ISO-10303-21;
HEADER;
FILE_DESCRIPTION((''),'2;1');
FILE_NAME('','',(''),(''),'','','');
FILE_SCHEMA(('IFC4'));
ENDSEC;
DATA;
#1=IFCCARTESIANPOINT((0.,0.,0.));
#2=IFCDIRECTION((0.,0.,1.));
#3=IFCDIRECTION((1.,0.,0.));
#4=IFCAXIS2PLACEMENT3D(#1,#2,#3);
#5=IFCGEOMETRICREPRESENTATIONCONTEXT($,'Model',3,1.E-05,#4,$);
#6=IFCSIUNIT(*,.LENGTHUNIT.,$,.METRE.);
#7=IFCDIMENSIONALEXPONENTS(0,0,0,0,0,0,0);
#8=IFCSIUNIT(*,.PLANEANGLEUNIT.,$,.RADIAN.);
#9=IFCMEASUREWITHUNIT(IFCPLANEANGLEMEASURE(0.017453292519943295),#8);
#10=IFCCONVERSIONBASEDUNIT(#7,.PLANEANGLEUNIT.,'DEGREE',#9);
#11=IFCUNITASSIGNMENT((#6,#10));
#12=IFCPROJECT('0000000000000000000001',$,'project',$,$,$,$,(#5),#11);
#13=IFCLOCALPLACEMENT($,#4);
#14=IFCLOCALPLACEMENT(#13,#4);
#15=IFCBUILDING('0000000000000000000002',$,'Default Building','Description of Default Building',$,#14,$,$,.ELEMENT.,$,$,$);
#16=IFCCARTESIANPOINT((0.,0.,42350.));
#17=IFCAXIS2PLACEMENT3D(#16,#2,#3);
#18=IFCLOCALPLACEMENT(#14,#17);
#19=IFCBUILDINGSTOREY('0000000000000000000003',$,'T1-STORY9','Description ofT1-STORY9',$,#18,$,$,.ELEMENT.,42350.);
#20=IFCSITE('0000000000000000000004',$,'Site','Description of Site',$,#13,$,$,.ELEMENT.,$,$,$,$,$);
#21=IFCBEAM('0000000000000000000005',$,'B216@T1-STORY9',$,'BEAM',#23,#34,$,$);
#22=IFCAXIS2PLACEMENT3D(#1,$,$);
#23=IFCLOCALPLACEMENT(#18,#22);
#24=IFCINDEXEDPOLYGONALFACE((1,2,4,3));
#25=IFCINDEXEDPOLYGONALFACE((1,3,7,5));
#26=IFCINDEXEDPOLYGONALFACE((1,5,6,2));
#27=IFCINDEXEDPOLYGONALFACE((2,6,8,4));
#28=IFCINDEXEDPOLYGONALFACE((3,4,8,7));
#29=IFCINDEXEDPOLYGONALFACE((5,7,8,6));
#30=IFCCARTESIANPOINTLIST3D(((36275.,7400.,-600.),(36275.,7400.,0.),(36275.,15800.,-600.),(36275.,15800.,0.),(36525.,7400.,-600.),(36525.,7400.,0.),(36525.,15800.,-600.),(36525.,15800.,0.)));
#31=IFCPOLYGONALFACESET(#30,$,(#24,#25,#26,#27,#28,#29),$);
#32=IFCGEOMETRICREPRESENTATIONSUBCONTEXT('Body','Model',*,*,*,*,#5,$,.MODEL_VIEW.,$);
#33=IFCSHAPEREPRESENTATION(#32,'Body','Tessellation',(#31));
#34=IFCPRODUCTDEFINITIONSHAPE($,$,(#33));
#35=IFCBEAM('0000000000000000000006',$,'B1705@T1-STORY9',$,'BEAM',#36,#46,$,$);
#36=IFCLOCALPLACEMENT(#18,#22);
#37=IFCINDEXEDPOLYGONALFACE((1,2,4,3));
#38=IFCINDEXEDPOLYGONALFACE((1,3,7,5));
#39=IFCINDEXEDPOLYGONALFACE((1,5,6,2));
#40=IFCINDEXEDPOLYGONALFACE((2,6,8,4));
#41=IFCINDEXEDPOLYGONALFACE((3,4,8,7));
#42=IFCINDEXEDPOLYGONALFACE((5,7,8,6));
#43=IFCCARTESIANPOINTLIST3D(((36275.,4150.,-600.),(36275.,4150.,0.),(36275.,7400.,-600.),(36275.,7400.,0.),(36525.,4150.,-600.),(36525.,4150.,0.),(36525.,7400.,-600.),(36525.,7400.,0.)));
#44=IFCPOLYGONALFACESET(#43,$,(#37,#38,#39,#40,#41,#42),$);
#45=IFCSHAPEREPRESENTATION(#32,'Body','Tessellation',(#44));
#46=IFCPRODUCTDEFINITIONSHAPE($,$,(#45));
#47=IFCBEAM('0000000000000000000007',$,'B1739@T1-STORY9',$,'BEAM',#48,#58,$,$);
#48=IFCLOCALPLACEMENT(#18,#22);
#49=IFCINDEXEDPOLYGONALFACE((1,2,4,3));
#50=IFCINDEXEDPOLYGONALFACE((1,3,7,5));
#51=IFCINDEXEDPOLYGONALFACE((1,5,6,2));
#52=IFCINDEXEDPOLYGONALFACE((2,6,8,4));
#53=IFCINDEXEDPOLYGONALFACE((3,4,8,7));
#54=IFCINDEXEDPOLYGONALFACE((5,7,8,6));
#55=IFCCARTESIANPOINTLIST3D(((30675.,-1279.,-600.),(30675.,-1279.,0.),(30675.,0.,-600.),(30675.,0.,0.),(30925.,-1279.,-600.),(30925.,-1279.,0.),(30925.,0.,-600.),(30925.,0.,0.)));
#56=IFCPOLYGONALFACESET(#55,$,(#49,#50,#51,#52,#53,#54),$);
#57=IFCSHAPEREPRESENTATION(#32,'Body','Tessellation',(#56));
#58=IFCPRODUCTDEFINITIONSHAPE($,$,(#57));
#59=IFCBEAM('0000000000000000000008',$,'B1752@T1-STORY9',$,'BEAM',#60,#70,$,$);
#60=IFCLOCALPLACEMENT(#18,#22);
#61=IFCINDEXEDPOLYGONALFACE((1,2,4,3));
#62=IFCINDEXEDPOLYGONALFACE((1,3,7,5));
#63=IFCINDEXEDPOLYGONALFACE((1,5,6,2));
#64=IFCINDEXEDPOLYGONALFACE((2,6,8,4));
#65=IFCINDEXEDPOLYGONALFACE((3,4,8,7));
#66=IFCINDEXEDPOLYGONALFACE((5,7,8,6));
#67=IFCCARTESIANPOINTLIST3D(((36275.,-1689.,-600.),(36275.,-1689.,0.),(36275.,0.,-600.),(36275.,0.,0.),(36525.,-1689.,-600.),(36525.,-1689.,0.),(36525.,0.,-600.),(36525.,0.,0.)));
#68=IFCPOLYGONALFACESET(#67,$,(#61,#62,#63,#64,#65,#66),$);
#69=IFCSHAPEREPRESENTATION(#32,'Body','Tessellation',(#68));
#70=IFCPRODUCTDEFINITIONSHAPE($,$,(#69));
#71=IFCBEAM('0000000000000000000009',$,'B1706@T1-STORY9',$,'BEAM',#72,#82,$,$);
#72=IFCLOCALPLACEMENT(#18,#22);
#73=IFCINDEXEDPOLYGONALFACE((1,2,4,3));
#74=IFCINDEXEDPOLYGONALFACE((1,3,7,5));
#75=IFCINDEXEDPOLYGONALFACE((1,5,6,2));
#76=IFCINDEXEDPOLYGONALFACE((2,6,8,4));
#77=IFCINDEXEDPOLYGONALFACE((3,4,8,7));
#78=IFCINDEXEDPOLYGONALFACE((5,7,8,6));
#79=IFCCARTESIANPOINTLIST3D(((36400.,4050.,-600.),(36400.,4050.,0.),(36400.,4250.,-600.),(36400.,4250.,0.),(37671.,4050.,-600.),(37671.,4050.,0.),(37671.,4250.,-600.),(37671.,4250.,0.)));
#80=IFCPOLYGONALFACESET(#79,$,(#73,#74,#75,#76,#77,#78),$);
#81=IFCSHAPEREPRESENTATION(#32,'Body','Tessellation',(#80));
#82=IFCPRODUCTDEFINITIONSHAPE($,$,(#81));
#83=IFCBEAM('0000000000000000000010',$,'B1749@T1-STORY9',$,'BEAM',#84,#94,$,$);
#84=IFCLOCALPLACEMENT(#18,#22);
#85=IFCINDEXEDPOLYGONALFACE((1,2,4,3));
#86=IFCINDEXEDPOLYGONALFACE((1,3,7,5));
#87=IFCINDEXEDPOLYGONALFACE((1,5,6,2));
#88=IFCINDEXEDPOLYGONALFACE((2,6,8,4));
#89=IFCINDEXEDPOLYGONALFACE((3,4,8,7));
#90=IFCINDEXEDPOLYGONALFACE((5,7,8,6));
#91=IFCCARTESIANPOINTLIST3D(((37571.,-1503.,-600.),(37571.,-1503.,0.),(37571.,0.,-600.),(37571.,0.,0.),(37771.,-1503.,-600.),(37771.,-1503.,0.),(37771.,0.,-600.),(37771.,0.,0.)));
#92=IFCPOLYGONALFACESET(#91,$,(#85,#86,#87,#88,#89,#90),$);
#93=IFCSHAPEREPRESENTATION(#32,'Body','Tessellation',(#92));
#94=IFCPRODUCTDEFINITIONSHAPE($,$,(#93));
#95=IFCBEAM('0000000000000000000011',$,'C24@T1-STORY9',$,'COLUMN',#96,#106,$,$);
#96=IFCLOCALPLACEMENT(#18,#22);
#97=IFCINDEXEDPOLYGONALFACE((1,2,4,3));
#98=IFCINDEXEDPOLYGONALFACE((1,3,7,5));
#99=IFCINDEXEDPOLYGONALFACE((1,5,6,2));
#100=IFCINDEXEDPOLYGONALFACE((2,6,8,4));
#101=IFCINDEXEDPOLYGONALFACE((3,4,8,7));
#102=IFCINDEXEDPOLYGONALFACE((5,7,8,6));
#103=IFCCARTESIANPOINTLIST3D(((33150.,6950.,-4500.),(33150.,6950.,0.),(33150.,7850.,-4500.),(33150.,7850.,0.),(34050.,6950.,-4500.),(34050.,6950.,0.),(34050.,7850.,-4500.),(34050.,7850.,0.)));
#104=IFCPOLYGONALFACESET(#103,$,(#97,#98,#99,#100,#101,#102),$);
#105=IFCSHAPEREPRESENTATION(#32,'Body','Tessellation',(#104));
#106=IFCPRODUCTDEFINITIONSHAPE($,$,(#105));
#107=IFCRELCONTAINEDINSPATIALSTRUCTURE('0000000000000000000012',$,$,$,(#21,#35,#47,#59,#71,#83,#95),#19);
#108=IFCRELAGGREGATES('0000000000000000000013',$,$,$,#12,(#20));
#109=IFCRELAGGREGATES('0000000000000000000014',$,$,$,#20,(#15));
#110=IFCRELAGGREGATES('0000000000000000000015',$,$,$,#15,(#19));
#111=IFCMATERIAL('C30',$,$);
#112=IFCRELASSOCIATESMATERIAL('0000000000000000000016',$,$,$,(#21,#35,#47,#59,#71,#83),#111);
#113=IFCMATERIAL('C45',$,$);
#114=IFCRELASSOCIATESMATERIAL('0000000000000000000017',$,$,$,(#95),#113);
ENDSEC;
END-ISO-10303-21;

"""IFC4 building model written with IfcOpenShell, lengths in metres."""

from ifc_helpers import new_model, entity, si_unit, converted_unit, frame, origin_with_axes, place, context, subcontext, project, spatial, rectangle, extrude, material, element, save


model = new_model("IFC4")

# Units and contexts
model_context = context("Model", 3, precision=1e-05, world=origin_with_axes())
body_context = subcontext(model_context, "Body", "Model", "MODEL_VIEW")
ifc_project = project(units=[si_unit("LENGTHUNIT", "METRE"), converted_unit("PLANEANGLEUNIT", "DEGREE", entity("IfcPlaneAngleMeasure", 0.017453292519943295), si_unit("PLANEANGLEUNIT", "RADIAN"), dimensions=[0, 0, 0, 0, 0, 0, 0])], contexts=[model_context])

# Site, building, storey
site_placement = place(None, origin_with_axes())
site = spatial("IfcSite", under=ifc_project, at=site_placement, Name="Site", Description="Description of Site", CompositionType="ELEMENT")
building_placement = place(site_placement, origin_with_axes())
building = spatial("IfcBuilding", under=site, at=building_placement, Name="Default Building", Description="Description of Default Building", CompositionType="ELEMENT")
storey_placement = place(building_placement, frame((0.0, 0.0, 42350.0), z_axis=(0.0, 0.0, 1.0), x_axis=(1.0, 0.0, 0.0)))
storey = spatial("IfcBuildingStorey", under=building, at=storey_placement, Name="T1-STORY9", Description="Description ofT1-STORY9", CompositionType="ELEMENT", Elevation=42350.0)

# Beams
ifc_material_1 = material(Name="C30")
beam_1_placement = place(storey_placement, frame((36400.0, 7400.0, -300.0), z_axis=(0.0, 1.0, 0.0), x_axis=(-1.0, 0.0, 0.0)))
element("IfcBeam", 1, at=beam_1_placement, inside=storey, material=ifc_material_1, Name="B216@T1-STORY9", ObjectType="BEAM", context=body_context, shape_type="SweptSolid", body=[
    extrude(rectangle(XDim=250.0, YDim=600.0), origin_with_axes(), (0.0, 0.0, 1.0), 8400.0),
])
beam_2_placement = place(storey_placement, frame((36400.0, 4150.0, -300.0), z_axis=(0.0, 1.0, 0.0), x_axis=(-1.0, 0.0, 0.0)))
element("IfcBeam", 2, at=beam_2_placement, inside=storey, material=ifc_material_1, Name="B1705@T1-STORY9", ObjectType="BEAM", context=body_context, shape_type="SweptSolid", body=[
    extrude(rectangle(XDim=250.0, YDim=600.0), origin_with_axes(), (0.0, 0.0, 1.0), 3250.0),
])
beam_3_placement = place(storey_placement, frame((30800.0, -1279.0, -300.0), z_axis=(0.0, 1.0, 0.0), x_axis=(-1.0, 0.0, 0.0)))
element("IfcBeam", 3, at=beam_3_placement, inside=storey, material=ifc_material_1, Name="B1739@T1-STORY9", ObjectType="BEAM", context=body_context, shape_type="SweptSolid", body=[
    extrude(rectangle(XDim=250.0, YDim=600.0), origin_with_axes(), (0.0, 0.0, 1.0), 1279.0),
])
beam_4_placement = place(storey_placement, frame((36400.0, -1689.0, -300.0), z_axis=(0.0, 1.0, 0.0), x_axis=(-1.0, 0.0, 0.0)))
element("IfcBeam", 4, at=beam_4_placement, inside=storey, material=ifc_material_1, Name="B1752@T1-STORY9", ObjectType="BEAM", context=body_context, shape_type="SweptSolid", body=[
    extrude(rectangle(XDim=250.0, YDim=600.0), origin_with_axes(), (0.0, 0.0, 1.0), 1689.0),
])
beam_5_placement = place(storey_placement, frame((36400.0, 4150.0, -300.0), z_axis=(1.0, 0.0, 0.0), x_axis=(0.0, 1.0, 0.0)))
element("IfcBeam", 5, at=beam_5_placement, inside=storey, material=ifc_material_1, Name="B1706@T1-STORY9", ObjectType="BEAM", context=body_context, shape_type="SweptSolid", body=[
    extrude(rectangle(XDim=200.0, YDim=600.0), origin_with_axes(), (0.0, 0.0, 1.0), 1271.0),
])
beam_6_placement = place(storey_placement, frame((37671.0, -1503.0, -300.0), z_axis=(0.0, 1.0, 0.0), x_axis=(-1.0, 0.0, 0.0)))
element("IfcBeam", 6, at=beam_6_placement, inside=storey, material=ifc_material_1, Name="B1749@T1-STORY9", ObjectType="BEAM", context=body_context, shape_type="SweptSolid", body=[
    extrude(rectangle(XDim=200.0, YDim=600.0), origin_with_axes(), (0.0, 0.0, 1.0), 1503.0),
])
ifc_material_2 = material(Name="C45")
beam_7_placement = place(storey_placement, frame((33600.0, 7400.0, -4500.0), z_axis=(0.0, 0.0, 1.0), x_axis=(-1.0, 0.0, 0.0)))
element("IfcBeam", 7, at=beam_7_placement, inside=storey, material=ifc_material_2, Name="C24@T1-STORY9", ObjectType="COLUMN", context=body_context, shape_type="SweptSolid", body=[
    extrude(rectangle(XDim=900.0, YDim=900.0), origin_with_axes(), (0.0, 0.0, 1.0), 4500.0),
])

save(model, "model.ifc")
